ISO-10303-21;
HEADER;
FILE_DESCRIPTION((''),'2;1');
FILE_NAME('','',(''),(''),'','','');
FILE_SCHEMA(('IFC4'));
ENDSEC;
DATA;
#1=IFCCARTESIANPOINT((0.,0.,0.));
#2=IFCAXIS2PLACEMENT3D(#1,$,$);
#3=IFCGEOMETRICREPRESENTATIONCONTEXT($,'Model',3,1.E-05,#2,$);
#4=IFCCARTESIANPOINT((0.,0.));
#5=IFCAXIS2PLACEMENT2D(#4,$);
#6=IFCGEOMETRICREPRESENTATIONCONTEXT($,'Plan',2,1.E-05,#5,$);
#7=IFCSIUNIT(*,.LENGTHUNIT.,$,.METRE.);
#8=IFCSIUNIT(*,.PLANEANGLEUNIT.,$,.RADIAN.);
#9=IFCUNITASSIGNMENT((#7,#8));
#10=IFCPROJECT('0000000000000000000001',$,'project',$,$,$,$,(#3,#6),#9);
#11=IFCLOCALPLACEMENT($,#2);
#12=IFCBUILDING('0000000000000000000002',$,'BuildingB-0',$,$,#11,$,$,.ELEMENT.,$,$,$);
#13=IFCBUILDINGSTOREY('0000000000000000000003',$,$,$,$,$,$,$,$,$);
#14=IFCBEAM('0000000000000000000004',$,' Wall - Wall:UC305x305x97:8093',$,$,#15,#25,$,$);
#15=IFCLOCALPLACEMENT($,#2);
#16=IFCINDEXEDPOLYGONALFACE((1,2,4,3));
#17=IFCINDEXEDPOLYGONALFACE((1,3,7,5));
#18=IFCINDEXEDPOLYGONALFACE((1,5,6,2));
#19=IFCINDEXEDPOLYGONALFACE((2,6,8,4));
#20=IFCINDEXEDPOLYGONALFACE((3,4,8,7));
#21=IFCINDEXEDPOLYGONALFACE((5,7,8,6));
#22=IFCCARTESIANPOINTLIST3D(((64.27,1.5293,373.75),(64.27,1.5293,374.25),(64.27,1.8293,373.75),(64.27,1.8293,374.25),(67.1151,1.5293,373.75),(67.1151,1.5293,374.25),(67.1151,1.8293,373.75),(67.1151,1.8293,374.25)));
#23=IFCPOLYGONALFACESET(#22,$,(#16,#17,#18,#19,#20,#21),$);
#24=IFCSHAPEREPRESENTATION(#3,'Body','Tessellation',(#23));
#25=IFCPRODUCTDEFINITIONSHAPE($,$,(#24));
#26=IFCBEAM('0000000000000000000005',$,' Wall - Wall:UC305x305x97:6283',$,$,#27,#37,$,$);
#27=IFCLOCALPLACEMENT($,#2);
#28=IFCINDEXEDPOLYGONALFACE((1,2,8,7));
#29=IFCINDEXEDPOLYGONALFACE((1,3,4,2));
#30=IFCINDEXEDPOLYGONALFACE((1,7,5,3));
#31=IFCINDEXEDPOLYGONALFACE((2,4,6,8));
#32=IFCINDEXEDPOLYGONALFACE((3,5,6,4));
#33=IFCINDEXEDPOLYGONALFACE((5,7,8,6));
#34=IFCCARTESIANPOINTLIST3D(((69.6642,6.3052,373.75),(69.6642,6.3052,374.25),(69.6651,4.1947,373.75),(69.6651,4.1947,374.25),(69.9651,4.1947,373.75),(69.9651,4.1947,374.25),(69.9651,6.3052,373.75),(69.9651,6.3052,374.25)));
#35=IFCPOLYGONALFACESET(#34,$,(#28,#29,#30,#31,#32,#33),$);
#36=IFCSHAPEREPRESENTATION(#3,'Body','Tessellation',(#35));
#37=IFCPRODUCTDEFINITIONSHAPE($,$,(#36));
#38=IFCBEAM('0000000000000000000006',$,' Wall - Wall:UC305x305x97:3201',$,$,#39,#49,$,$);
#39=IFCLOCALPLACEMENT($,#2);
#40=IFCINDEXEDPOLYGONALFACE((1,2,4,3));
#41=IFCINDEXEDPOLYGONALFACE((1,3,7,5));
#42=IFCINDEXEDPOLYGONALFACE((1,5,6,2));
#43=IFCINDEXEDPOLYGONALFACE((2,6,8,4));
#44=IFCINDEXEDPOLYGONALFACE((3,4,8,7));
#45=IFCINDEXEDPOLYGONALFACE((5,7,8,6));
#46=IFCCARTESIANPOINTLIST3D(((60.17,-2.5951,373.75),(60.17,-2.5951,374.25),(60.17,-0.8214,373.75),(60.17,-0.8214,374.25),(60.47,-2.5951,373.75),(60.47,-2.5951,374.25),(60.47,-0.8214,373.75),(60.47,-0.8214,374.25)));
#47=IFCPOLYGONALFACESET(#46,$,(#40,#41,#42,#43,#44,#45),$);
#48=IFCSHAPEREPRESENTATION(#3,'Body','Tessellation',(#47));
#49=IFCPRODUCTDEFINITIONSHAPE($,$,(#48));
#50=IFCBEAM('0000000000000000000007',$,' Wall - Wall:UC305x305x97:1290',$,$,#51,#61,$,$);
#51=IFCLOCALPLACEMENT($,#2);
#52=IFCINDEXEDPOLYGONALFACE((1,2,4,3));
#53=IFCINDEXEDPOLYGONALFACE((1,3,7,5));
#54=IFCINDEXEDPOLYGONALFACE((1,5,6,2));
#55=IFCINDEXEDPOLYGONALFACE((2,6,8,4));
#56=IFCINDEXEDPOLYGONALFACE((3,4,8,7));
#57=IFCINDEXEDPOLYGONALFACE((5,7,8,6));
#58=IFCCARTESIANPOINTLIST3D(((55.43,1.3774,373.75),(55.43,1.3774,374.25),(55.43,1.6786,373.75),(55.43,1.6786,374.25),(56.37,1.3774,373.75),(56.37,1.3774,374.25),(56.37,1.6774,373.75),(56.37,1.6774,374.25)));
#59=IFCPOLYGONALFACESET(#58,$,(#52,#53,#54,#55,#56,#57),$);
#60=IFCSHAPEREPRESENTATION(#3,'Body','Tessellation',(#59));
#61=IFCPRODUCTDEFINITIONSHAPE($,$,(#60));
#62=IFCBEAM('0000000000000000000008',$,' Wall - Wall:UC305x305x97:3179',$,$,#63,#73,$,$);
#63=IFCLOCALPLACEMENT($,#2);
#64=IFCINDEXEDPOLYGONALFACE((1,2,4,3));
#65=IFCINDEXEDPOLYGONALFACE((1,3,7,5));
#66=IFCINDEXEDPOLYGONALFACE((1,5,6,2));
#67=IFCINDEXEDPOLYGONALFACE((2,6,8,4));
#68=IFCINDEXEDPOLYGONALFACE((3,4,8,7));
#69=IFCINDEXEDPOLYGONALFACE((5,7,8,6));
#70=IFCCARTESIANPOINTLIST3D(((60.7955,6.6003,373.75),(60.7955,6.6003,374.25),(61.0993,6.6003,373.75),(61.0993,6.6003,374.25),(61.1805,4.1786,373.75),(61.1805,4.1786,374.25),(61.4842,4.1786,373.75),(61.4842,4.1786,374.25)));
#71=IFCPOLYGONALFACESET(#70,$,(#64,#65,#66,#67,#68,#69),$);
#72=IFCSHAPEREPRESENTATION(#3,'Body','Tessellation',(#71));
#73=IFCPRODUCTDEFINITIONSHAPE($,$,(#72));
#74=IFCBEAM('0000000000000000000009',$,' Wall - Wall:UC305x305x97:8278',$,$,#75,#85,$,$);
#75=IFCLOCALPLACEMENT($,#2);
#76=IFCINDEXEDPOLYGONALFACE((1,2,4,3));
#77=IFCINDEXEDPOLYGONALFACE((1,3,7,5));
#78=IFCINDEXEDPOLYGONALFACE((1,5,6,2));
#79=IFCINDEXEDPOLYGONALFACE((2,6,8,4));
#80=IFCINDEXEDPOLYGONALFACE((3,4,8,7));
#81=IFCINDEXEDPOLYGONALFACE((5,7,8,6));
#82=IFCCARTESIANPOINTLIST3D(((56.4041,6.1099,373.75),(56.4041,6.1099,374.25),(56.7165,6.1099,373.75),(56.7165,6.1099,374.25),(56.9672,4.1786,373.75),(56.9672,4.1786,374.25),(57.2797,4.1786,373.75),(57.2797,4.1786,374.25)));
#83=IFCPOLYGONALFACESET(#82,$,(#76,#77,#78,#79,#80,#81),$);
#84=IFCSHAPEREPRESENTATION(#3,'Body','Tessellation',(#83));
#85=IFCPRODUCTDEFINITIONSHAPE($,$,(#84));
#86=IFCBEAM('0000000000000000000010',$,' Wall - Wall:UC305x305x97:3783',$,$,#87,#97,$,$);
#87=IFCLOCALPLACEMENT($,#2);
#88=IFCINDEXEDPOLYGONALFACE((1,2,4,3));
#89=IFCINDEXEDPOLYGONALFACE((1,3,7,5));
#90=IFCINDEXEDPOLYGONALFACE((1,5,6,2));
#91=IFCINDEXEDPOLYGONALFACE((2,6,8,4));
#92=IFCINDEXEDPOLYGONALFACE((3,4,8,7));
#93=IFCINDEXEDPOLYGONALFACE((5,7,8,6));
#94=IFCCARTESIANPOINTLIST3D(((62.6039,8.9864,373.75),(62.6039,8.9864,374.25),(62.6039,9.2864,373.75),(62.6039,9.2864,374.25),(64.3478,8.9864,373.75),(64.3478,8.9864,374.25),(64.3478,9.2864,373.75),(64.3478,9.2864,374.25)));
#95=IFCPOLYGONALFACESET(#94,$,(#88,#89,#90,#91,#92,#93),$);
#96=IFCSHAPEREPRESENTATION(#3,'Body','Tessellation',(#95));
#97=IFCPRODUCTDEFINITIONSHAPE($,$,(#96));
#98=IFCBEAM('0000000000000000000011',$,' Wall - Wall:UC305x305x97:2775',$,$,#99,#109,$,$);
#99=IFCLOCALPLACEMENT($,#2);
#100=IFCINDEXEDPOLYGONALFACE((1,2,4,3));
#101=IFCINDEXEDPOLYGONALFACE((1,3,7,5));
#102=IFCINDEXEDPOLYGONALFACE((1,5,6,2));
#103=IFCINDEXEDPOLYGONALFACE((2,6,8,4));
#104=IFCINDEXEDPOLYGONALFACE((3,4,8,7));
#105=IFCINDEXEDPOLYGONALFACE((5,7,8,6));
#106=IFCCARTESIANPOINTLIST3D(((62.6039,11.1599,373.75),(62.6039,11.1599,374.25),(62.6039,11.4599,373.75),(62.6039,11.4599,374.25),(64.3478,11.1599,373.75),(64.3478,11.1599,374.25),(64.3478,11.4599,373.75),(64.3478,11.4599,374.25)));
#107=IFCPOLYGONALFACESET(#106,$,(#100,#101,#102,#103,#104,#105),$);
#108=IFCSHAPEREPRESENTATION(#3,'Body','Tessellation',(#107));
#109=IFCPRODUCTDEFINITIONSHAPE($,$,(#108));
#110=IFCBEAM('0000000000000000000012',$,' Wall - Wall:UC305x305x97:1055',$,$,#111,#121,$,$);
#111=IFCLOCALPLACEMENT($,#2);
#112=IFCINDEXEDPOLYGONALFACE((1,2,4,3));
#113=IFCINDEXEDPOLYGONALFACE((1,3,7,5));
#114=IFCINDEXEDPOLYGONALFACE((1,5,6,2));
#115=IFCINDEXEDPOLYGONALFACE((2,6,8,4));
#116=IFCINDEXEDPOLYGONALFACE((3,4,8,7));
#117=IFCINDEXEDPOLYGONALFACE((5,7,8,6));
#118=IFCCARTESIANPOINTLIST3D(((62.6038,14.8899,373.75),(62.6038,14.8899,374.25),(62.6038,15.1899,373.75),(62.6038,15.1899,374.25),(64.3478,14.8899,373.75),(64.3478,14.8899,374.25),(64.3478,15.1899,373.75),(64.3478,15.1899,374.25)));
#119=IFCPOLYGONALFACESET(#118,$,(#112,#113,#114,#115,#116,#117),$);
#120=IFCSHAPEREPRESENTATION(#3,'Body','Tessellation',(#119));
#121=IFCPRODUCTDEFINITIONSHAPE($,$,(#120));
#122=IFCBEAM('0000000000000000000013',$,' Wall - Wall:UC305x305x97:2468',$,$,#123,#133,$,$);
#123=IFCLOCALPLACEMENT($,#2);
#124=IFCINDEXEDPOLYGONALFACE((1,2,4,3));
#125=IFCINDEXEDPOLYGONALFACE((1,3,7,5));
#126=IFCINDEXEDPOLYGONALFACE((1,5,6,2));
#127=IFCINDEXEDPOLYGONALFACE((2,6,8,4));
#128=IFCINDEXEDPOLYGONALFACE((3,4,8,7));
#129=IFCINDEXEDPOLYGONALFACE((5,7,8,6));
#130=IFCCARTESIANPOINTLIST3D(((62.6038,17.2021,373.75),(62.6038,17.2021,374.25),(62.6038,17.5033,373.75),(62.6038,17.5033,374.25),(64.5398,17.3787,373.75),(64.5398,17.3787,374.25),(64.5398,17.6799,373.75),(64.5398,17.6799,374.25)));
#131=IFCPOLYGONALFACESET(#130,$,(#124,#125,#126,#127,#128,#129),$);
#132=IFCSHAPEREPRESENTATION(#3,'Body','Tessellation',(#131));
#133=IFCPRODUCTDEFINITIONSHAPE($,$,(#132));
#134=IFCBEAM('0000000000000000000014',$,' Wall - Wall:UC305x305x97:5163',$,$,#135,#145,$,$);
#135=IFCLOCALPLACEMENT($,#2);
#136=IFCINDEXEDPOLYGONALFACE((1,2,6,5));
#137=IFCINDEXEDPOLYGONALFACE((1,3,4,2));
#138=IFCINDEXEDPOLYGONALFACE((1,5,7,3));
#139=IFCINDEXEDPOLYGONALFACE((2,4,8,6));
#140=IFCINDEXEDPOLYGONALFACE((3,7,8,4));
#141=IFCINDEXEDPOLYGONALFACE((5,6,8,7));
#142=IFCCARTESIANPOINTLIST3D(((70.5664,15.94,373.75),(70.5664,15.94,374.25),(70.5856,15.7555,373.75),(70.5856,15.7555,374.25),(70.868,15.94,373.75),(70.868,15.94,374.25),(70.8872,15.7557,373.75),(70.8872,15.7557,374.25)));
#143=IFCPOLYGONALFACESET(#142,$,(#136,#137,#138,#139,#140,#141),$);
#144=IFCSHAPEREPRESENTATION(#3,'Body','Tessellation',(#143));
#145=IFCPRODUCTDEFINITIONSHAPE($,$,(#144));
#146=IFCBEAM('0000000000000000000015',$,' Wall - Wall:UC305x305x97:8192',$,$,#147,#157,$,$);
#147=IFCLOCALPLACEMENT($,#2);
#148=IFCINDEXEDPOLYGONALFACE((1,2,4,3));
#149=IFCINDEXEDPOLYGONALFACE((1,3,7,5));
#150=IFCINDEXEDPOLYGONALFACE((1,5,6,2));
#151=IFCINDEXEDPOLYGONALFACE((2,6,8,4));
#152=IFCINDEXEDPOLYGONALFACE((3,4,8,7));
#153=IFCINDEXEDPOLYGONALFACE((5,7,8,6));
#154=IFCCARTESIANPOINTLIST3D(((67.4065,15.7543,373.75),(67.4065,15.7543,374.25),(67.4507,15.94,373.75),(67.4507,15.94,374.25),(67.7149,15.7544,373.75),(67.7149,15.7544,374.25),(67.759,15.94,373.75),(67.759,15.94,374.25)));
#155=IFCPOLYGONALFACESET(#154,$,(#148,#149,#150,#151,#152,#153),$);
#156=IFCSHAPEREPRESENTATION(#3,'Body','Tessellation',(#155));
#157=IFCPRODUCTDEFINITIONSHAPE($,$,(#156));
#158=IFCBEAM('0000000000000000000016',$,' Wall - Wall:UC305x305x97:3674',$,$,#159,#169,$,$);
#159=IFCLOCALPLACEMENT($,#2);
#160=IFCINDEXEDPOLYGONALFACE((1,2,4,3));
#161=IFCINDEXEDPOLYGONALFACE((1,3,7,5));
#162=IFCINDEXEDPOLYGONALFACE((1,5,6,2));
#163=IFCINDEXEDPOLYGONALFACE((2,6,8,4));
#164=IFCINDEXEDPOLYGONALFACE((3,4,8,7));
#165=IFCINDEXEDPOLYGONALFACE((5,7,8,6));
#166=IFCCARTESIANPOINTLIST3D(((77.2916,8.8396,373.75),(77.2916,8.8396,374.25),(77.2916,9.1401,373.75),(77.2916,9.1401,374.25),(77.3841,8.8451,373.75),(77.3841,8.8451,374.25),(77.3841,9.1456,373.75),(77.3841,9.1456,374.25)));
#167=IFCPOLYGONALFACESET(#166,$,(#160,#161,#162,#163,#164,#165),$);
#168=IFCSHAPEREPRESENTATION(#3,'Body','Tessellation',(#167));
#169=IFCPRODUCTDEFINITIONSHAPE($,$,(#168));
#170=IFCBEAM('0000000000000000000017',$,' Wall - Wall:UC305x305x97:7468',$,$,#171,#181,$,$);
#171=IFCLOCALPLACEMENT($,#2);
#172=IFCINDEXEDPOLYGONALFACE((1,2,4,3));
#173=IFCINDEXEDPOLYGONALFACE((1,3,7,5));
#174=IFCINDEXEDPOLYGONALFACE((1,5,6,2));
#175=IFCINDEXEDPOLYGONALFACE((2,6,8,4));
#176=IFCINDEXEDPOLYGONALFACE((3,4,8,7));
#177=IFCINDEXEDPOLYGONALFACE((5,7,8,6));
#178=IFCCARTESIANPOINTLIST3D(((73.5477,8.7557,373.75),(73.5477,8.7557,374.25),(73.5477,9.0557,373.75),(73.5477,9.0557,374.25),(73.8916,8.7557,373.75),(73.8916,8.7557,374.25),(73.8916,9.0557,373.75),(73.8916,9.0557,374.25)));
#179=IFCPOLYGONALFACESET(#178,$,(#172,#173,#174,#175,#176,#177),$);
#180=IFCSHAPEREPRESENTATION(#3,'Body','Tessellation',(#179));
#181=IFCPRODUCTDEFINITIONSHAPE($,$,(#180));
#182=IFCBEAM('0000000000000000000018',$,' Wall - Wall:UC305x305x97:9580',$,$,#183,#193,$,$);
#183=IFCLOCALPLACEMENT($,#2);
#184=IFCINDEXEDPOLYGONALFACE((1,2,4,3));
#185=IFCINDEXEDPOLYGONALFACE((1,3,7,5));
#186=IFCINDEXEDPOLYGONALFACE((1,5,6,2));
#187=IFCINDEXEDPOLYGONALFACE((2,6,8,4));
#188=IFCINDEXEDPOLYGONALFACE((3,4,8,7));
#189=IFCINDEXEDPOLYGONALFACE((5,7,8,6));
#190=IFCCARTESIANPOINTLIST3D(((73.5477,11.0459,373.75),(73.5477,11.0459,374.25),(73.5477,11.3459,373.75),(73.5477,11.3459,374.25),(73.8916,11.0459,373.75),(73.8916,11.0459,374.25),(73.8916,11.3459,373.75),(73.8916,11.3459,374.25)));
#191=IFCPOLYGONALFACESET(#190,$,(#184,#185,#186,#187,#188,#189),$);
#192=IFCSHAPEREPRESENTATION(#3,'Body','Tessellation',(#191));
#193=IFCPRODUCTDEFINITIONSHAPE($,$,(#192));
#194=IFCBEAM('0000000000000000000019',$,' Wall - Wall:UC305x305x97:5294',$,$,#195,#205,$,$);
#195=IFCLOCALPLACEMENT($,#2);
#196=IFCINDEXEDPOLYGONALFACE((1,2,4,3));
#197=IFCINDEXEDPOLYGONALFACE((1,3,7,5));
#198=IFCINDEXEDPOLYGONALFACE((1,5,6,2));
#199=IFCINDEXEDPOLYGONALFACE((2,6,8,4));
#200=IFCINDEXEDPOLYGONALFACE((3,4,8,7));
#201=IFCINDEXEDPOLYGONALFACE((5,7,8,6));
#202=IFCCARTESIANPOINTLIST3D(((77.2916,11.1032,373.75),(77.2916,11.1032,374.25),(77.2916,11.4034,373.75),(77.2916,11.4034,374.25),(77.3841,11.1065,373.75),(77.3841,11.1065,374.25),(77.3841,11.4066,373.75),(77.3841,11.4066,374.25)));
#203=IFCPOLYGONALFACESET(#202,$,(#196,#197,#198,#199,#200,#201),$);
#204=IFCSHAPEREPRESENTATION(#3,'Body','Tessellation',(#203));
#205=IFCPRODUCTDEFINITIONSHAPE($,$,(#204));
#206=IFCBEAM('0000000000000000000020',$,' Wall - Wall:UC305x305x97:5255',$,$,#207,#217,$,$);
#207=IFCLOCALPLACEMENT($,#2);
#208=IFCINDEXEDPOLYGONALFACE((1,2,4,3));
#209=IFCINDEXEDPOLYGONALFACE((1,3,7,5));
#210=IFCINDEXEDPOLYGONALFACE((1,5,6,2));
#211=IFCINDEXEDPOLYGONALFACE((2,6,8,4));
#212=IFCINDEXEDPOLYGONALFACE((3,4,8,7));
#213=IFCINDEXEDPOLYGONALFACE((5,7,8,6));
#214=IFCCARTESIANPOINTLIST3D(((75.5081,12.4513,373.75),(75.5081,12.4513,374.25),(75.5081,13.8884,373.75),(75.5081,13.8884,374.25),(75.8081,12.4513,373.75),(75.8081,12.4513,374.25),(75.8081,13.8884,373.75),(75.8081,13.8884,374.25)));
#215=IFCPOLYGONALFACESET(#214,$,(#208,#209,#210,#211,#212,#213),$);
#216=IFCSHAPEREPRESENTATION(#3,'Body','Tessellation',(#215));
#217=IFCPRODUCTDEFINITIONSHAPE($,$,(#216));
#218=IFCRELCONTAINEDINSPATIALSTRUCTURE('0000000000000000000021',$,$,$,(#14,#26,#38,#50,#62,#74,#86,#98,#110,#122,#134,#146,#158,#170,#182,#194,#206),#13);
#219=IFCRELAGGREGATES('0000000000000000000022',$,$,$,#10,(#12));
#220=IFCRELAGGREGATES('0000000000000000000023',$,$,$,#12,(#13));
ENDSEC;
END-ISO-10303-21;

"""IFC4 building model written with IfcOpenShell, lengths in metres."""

from ifc_helpers import new_model, si_unit, origin, origin_2d, place, context, project, spatial, polyline, outline, extrude, element, save


model = new_model("IFC4")

# Units and contexts
model_context = context("Model", 3, precision=1e-05, world=origin())
plan_context = context("Plan", 2, precision=1e-05, world=origin_2d())
ifc_project = project(units=[si_unit("LENGTHUNIT", "METRE"), si_unit("PLANEANGLEUNIT", "RADIAN")], contexts=[model_context, plan_context])

# Building, storey
building_placement = place(None, origin())
building = spatial("IfcBuilding", under=ifc_project, at=building_placement, Name="BuildingB-0", CompositionType="ELEMENT")
storey = spatial("IfcBuildingStorey", under=building)

# Beams
element("IfcBeam", 1, inside=storey, Name=" Wall - Wall:UC305x305x97:8093", context=model_context, shape_type="SweptSolid", body=[
    extrude(outline(polyline([(67.1151, 1.5293, 373.75), (67.1151, 1.8293, 373.75), (64.27, 1.8293, 373.75), (64.27, 1.5293, 373.75), (67.1151, 1.5293, 373.75)])), None, (0.0, 0.0, 1.0), 0.5),
])
element("IfcBeam", 2, inside=storey, Name=" Wall - Wall:UC305x305x97:6283", context=model_context, shape_type="SweptSolid", body=[
    extrude(outline(polyline([(69.9651, 4.1947, 373.75), (69.6651, 4.1947, 373.75), (69.6642, 6.3052, 373.75), (69.9651, 6.3052, 373.75), (69.9651, 4.1947, 373.75)])), None, (0.0, 0.0, 1.0), 0.5),
])
element("IfcBeam", 3, inside=storey, Name=" Wall - Wall:UC305x305x97:3201", context=model_context, shape_type="SweptSolid", body=[
    extrude(outline(polyline([(60.47, -2.5951, 373.75), (60.17, -2.5951, 373.75), (60.17, -0.8214, 373.75), (60.47, -0.8214, 373.75), (60.47, -2.5951, 373.75)])), None, (0.0, 0.0, 1.0), 0.5),
])
element("IfcBeam", 4, inside=storey, Name=" Wall - Wall:UC305x305x97:1290", context=model_context, shape_type="SweptSolid", body=[
    extrude(outline(polyline([(56.37, 1.3774, 373.75), (56.37, 1.6774, 373.75), (55.43, 1.6786, 373.75), (55.43, 1.3774, 373.75), (56.37, 1.3774, 373.75)])), None, (0.0, 0.0, 1.0), 0.5),
])
element("IfcBeam", 5, inside=storey, Name=" Wall - Wall:UC305x305x97:3179", context=model_context, shape_type="SweptSolid", body=[
    extrude(outline(polyline([(61.4842, 4.1786, 373.75), (61.0993, 6.6003, 373.75), (60.7955, 6.6003, 373.75), (61.1805, 4.1786, 373.75), (61.4842, 4.1786, 373.75)])), None, (0.0, 0.0, 1.0), 0.5),
])
element("IfcBeam", 6, inside=storey, Name=" Wall - Wall:UC305x305x97:8278", context=model_context, shape_type="SweptSolid", body=[
    extrude(outline(polyline([(56.9672, 4.1786, 373.75), (57.2797, 4.1786, 373.75), (56.7165, 6.1099, 373.75), (56.4041, 6.1099, 373.75), (56.9672, 4.1786, 373.75)])), None, (0.0, 0.0, 1.0), 0.5),
])
element("IfcBeam", 7, inside=storey, Name=" Wall - Wall:UC305x305x97:3783", context=model_context, shape_type="SweptSolid", body=[
    extrude(outline(polyline([(64.3478, 8.9864, 373.75), (62.6039, 8.9864, 373.75), (62.6039, 9.2864, 373.75), (64.3478, 9.2864, 373.75), (64.3478, 8.9864, 373.75)])), None, (0.0, 0.0, 1.0), 0.5),
])
element("IfcBeam", 8, inside=storey, Name=" Wall - Wall:UC305x305x97:2775", context=model_context, shape_type="SweptSolid", body=[
    extrude(outline(polyline([(64.3478, 11.1599, 373.75), (64.3478, 11.4599, 373.75), (62.6039, 11.4599, 373.75), (62.6039, 11.1599, 373.75), (64.3478, 11.1599, 373.75)])), None, (0.0, 0.0, 1.0), 0.5),
])
element("IfcBeam", 9, inside=storey, Name=" Wall - Wall:UC305x305x97:1055", context=model_context, shape_type="SweptSolid", body=[
    extrude(outline(polyline([(64.3478, 14.8899, 373.75), (64.3478, 15.1899, 373.75), (62.6038, 15.1899, 373.75), (62.6038, 14.8899, 373.75), (64.3478, 14.8899, 373.75)])), None, (0.0, 0.0, 1.0), 0.5),
])
element("IfcBeam", 10, inside=storey, Name=" Wall - Wall:UC305x305x97:2468", context=model_context, shape_type="SweptSolid", body=[
    extrude(outline(polyline([(64.5398, 17.3787, 373.75), (64.5398, 17.6799, 373.75), (62.6038, 17.5033, 373.75), (62.6038, 17.2021, 373.75), (64.5398, 17.3787, 373.75)])), None, (0.0, 0.0, 1.0), 0.5),
])
element("IfcBeam", 11, inside=storey, Name=" Wall - Wall:UC305x305x97:5163", context=model_context, shape_type="SweptSolid", body=[
    extrude(outline(polyline([(70.8872, 15.7557, 373.75), (70.868, 15.94, 373.75), (70.5664, 15.94, 373.75), (70.5856, 15.7555, 373.75), (70.8872, 15.7557, 373.75)])), None, (0.0, 0.0, 1.0), 0.5),
])
element("IfcBeam", 12, inside=storey, Name=" Wall - Wall:UC305x305x97:8192", context=model_context, shape_type="SweptSolid", body=[
    extrude(outline(polyline([(67.7149, 15.7544, 373.75), (67.759, 15.94, 373.75), (67.4507, 15.94, 373.75), (67.4065, 15.7543, 373.75), (67.7149, 15.7544, 373.75)])), None, (0.0, 0.0, 1.0), 0.5),
])
element("IfcBeam", 13, inside=storey, Name=" Wall - Wall:UC305x305x97:3674", context=model_context, shape_type="SweptSolid", body=[
    extrude(outline(polyline([(77.3841, 8.8451, 373.75), (77.2916, 8.8396, 373.75), (77.2916, 9.1401, 373.75), (77.3841, 9.1456, 373.75), (77.3841, 8.8451, 373.75)])), None, (0.0, 0.0, 1.0), 0.5),
])
element("IfcBeam", 14, inside=storey, Name=" Wall - Wall:UC305x305x97:7468", context=model_context, shape_type="SweptSolid", body=[
    extrude(outline(polyline([(73.8916, 8.7557, 373.75), (73.5477, 8.7557, 373.75), (73.5477, 9.0557, 373.75), (73.8916, 9.0557, 373.75), (73.8916, 8.7557, 373.75)])), None, (0.0, 0.0, 1.0), 0.5),
])
element("IfcBeam", 15, inside=storey, Name=" Wall - Wall:UC305x305x97:9580", context=model_context, shape_type="SweptSolid", body=[
    extrude(outline(polyline([(73.8916, 11.0459, 373.75), (73.5477, 11.0459, 373.75), (73.5477, 11.3459, 373.75), (73.8916, 11.3459, 373.75), (73.8916, 11.0459, 373.75)])), None, (0.0, 0.0, 1.0), 0.5),
])
element("IfcBeam", 16, inside=storey, Name=" Wall - Wall:UC305x305x97:5294", context=model_context, shape_type="SweptSolid", body=[
    extrude(outline(polyline([(77.3841, 11.1065, 373.75), (77.2916, 11.1032, 373.75), (77.2916, 11.4034, 373.75), (77.3841, 11.4066, 373.75), (77.3841, 11.1065, 373.75)])), None, (0.0, 0.0, 1.0), 0.5),
])
element("IfcBeam", 17, inside=storey, Name=" Wall - Wall:UC305x305x97:5255", context=model_context, shape_type="SweptSolid", body=[
    extrude(outline(polyline([(75.8081, 12.4513, 373.75), (75.5081, 12.4513, 373.75), (75.5081, 13.8884, 373.75), (75.8081, 13.8884, 373.75), (75.8081, 12.4513, 373.75)])), None, (0.0, 0.0, 1.0), 0.5),
])

save(model, "model.ifc")
